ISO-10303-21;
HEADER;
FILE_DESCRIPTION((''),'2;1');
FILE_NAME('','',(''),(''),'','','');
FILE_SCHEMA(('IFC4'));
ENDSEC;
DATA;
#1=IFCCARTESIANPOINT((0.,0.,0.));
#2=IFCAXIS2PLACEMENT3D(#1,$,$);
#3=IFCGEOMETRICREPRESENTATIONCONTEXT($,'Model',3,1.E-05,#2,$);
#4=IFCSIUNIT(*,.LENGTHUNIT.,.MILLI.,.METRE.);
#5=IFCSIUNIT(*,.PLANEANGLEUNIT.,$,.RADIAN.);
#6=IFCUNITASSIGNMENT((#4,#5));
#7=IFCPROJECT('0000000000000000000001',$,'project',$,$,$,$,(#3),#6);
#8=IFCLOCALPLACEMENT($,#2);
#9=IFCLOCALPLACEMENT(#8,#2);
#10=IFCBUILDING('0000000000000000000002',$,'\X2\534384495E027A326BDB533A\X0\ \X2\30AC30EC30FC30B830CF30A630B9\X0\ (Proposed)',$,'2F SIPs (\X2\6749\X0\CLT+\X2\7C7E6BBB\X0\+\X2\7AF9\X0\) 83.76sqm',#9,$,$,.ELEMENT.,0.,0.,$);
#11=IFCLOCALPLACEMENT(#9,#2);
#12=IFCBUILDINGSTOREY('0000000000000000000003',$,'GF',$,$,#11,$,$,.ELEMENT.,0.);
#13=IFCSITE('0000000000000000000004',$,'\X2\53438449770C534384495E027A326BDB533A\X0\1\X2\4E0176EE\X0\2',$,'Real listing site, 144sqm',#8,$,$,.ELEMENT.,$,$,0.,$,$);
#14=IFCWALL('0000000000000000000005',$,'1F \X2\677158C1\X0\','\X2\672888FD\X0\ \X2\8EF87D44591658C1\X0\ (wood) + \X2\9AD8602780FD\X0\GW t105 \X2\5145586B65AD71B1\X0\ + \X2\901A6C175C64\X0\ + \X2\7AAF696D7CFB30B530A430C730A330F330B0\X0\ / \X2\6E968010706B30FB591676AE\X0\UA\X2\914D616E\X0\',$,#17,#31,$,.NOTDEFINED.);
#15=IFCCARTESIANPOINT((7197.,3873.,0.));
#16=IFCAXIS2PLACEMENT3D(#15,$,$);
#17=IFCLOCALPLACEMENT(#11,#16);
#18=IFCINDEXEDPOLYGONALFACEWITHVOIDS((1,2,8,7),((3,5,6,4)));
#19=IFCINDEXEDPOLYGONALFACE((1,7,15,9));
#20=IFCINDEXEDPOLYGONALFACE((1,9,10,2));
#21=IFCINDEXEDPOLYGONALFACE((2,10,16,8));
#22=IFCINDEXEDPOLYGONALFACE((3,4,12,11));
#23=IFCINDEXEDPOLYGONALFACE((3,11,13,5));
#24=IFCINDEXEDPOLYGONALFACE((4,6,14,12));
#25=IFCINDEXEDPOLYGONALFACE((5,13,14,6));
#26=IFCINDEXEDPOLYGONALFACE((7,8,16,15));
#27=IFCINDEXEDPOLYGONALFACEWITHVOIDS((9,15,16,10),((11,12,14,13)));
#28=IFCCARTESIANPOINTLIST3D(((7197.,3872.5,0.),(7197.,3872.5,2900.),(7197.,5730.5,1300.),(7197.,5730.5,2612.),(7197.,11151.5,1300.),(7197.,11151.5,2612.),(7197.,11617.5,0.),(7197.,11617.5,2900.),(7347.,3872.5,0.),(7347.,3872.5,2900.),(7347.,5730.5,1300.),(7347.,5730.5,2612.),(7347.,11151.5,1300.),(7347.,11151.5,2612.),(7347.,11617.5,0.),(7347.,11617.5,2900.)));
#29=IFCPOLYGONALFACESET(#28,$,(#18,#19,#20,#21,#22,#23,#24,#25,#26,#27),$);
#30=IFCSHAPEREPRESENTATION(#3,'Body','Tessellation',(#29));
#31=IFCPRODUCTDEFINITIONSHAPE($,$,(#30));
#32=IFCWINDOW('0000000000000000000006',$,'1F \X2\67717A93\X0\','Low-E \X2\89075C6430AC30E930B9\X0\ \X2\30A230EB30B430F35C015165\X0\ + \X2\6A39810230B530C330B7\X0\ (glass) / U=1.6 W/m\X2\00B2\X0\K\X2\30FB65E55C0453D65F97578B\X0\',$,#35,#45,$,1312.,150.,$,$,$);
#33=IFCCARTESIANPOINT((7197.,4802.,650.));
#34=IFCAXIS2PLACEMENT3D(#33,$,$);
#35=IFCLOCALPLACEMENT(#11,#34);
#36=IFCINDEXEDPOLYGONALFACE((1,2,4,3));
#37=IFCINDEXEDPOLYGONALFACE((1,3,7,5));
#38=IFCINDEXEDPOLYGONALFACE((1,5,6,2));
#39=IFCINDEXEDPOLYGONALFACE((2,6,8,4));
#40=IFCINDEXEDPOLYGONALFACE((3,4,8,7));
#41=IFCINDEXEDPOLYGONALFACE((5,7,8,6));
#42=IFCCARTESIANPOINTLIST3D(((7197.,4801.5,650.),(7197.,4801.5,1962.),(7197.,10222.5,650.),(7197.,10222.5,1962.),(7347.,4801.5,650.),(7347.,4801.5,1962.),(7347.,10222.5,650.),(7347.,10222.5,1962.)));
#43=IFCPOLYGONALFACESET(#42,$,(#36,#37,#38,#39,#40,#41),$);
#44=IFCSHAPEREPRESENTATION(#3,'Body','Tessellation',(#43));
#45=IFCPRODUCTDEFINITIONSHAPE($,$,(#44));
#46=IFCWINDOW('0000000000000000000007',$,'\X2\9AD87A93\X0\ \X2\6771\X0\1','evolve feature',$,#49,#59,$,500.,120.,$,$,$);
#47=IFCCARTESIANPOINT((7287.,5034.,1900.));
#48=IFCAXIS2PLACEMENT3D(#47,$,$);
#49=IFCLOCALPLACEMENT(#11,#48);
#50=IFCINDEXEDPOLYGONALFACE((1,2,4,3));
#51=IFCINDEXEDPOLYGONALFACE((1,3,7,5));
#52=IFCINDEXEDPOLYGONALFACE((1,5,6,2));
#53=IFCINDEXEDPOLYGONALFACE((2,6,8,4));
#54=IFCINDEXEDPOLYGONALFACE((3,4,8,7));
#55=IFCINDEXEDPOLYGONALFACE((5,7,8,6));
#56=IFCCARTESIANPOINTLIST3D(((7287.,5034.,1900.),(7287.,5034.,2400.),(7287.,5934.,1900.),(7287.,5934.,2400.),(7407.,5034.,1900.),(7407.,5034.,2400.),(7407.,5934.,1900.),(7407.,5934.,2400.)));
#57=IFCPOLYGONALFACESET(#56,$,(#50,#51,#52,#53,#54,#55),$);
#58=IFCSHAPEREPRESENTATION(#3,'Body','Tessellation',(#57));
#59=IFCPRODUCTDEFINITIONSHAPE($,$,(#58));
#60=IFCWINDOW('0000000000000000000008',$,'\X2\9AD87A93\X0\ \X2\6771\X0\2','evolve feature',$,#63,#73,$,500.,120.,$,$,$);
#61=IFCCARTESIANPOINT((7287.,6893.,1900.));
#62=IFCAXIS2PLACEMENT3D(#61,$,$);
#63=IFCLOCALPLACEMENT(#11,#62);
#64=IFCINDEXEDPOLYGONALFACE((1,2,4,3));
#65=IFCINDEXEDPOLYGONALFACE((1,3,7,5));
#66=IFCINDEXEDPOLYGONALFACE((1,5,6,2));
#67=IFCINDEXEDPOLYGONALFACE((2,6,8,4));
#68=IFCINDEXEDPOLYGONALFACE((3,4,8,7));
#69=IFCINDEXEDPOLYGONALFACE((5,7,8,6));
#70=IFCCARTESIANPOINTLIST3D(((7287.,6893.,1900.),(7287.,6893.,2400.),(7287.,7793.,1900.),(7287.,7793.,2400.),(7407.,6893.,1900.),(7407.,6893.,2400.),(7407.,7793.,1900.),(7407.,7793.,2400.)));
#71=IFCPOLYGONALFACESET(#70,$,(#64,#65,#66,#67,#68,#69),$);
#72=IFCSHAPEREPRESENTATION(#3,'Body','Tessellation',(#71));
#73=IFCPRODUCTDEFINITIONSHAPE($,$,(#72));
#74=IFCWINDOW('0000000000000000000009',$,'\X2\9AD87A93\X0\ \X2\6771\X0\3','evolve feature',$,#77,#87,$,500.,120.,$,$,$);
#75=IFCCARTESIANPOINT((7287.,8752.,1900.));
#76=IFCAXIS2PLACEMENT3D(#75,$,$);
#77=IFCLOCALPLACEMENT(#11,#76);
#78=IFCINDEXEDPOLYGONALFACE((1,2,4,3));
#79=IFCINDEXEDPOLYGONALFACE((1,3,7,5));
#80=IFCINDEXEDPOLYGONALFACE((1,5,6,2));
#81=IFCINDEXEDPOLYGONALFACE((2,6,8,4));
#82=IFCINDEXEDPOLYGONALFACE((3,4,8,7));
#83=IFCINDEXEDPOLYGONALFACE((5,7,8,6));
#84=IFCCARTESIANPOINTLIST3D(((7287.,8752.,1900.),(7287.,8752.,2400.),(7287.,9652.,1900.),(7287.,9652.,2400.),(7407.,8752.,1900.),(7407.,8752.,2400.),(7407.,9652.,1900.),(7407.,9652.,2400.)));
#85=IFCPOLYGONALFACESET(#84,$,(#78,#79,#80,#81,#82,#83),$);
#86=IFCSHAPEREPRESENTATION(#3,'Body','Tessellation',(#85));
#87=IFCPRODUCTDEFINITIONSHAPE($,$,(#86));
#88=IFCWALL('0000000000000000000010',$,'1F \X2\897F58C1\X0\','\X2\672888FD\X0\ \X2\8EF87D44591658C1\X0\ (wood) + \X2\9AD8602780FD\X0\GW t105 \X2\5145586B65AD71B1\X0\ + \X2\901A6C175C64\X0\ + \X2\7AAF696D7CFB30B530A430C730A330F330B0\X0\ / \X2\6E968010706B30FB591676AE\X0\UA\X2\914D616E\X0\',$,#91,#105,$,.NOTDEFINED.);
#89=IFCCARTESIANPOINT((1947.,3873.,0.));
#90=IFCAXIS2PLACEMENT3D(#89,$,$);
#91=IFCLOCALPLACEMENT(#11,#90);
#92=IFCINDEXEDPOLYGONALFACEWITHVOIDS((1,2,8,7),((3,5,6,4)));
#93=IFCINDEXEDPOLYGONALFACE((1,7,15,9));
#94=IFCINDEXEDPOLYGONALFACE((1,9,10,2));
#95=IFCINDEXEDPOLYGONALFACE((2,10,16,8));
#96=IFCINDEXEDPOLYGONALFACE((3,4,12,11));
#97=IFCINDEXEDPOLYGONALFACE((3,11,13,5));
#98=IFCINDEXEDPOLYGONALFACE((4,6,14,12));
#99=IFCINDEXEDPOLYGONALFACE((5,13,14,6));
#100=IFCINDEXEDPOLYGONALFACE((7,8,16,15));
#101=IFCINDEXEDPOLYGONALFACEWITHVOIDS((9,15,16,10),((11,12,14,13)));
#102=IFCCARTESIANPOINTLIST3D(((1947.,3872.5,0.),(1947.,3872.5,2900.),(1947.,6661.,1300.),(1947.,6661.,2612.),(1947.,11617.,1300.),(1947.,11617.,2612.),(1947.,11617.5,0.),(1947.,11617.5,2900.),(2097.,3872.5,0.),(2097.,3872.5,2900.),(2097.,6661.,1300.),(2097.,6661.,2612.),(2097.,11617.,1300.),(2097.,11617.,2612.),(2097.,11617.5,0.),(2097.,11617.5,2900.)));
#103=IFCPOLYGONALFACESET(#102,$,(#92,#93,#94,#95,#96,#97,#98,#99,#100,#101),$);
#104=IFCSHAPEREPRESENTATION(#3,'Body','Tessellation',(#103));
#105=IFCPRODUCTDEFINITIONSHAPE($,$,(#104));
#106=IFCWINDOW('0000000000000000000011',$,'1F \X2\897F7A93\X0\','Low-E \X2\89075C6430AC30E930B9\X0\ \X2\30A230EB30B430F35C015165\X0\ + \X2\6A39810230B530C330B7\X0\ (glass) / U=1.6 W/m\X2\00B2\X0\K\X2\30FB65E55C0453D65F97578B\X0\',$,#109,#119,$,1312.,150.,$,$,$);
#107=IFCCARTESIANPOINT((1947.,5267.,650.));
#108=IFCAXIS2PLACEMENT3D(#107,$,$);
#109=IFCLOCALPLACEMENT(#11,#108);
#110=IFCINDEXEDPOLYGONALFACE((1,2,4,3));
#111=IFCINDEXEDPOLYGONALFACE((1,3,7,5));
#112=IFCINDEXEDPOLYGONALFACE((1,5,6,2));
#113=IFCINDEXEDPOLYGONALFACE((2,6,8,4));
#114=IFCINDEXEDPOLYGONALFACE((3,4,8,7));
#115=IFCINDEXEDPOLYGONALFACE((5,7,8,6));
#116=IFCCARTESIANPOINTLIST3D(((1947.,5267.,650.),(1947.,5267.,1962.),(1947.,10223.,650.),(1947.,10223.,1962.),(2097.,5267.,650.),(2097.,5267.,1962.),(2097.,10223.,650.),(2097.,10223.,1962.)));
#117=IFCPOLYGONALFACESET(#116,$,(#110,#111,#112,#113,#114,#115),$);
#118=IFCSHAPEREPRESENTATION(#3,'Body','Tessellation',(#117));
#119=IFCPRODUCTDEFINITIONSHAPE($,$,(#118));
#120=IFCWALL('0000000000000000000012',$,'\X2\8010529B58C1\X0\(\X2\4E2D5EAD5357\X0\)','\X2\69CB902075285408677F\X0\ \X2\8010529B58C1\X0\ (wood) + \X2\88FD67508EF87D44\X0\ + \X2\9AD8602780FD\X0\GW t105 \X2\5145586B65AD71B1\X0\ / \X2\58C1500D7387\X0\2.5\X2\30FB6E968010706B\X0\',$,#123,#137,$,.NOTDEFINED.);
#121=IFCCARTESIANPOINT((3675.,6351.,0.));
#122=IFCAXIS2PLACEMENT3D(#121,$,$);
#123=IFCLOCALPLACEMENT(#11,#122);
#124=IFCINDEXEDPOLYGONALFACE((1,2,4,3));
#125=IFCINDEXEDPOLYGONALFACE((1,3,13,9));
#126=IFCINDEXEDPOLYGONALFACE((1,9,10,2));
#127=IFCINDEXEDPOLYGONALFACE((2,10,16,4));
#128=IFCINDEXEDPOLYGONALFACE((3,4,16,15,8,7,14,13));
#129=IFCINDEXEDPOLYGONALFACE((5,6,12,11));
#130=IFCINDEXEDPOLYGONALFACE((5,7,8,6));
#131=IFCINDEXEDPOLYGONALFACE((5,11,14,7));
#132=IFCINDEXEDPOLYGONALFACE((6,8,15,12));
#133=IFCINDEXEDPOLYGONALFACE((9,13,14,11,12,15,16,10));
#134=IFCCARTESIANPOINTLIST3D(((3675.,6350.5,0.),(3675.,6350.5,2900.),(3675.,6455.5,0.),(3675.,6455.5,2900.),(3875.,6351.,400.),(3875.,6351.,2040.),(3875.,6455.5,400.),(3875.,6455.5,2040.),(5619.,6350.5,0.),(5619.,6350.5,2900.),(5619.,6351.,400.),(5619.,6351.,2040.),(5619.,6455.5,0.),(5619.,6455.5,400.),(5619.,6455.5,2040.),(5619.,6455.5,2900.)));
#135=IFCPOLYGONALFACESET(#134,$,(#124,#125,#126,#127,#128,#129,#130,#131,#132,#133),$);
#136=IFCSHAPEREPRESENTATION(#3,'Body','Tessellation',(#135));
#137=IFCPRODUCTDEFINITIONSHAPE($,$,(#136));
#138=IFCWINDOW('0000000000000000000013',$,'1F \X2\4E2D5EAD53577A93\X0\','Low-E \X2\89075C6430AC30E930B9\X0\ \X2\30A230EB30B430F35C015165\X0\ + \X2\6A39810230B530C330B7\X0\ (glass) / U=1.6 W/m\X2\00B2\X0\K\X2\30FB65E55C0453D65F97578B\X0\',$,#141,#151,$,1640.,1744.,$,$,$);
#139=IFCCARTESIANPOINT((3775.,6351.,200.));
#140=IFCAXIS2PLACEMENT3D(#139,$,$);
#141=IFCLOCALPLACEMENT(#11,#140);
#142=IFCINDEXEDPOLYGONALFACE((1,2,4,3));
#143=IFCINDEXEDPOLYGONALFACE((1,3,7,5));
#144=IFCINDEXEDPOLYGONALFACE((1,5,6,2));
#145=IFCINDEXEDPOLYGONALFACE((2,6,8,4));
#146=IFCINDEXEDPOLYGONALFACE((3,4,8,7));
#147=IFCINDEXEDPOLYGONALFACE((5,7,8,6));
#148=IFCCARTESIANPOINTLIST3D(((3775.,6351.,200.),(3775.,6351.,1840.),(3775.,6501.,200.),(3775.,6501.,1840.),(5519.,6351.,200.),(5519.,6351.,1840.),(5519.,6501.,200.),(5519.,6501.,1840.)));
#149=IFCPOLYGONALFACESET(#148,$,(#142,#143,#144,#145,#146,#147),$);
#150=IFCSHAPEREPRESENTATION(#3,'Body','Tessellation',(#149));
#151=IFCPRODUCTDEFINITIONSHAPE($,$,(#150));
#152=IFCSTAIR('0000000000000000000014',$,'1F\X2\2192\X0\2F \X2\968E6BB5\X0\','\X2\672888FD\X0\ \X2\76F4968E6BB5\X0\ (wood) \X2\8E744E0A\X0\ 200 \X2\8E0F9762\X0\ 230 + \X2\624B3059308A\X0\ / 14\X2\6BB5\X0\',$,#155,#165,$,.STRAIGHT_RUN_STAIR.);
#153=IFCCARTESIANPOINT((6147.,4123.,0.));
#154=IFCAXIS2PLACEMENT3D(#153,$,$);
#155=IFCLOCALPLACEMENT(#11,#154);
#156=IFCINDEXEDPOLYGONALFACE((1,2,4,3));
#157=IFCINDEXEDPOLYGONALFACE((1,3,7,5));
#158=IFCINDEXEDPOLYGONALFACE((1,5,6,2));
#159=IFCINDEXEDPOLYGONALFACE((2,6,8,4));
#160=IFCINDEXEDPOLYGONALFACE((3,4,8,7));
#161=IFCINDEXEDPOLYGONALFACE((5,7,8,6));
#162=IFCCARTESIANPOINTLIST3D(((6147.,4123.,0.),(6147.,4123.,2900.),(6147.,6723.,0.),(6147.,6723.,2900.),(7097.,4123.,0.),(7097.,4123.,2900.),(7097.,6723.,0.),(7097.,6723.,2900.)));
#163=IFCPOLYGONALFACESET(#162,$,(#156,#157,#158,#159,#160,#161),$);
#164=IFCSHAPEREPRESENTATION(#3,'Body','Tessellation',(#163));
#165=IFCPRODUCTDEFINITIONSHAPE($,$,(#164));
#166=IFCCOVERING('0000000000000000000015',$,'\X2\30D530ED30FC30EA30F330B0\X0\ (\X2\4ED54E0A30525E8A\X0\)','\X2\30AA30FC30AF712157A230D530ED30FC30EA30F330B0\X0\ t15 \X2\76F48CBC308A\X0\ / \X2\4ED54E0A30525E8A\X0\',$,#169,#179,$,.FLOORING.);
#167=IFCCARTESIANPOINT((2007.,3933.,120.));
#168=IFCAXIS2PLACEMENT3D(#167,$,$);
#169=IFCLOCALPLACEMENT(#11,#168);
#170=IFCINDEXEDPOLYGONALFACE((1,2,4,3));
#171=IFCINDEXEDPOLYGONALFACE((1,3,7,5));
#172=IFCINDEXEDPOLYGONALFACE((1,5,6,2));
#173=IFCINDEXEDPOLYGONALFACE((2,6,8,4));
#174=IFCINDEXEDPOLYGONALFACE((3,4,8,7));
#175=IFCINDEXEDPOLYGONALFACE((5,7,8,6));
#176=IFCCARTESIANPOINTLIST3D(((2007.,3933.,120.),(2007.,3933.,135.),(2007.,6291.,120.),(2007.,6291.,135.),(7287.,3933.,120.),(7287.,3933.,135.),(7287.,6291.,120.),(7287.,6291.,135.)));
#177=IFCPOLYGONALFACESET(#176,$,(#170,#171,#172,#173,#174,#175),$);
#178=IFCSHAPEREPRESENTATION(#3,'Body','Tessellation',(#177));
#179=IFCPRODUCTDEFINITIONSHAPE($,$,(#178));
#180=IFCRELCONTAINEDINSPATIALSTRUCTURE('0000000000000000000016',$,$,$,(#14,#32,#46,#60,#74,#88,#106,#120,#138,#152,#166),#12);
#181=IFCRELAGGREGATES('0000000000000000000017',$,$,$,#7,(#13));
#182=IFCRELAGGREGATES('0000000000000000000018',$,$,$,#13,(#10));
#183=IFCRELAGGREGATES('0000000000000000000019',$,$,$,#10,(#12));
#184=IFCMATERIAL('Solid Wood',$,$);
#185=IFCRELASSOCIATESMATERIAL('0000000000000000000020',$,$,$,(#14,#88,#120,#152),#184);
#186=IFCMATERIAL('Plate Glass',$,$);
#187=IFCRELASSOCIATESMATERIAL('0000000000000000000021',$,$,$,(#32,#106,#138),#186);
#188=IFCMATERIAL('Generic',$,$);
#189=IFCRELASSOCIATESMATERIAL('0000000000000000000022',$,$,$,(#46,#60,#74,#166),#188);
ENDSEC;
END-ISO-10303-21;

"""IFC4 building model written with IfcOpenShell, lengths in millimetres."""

from ifc_helpers import new_model, si_unit, frame, frame_2d, origin, place, context, project, spatial, rectangle, extrude, material, element, fill, save


model = new_model("IFC4")

# Units and contexts
model_context = context("Model", 3, precision=1e-05, world=origin())
ifc_project = project(units=[si_unit("LENGTHUNIT", "METRE", prefix="MILLI"), si_unit("PLANEANGLEUNIT", "RADIAN")], contexts=[model_context])

# Site, building, storey
site_placement = place(None, origin())
site = spatial("IfcSite", under=ifc_project, at=site_placement, Name="千葉県千葉市稲毛区1丁目2", ObjectType="Real listing site, 144sqm", CompositionType="ELEMENT", RefElevation=0.0)
building_placement = place(site_placement, origin())
building = spatial("IfcBuilding", under=site, at=building_placement, Name="千葉市稲毛区 ガレージハウス (Proposed)", ObjectType="2F SIPs (杉CLT+籾殻+竹) 83.76sqm", CompositionType="ELEMENT", ElevationOfRefHeight=0.0, ElevationOfTerrain=0.0)
storey_placement = place(building_placement, origin())
storey = spatial("IfcBuildingStorey", under=building, at=storey_placement, Name="GF", CompositionType="ELEMENT", Elevation=0.0)

# Shared definitions
ifc_material_1 = material(Name="Solid Wood")
ifc_material_2 = material(Name="Generic")

# Shared definitions
ifc_material_3 = material(Name="Plate Glass")

# Wall, openings, windows
wall_1_placement = place(storey_placement, frame((7197.0, 3873.0, 0.0)))
wall_1 = element("IfcWall", 1, at=wall_1_placement, inside=storey, material=ifc_material_1, Name="1F 東壁", Description="木製 軸組外壁 (wood) + 高性能GW t105 充填断熱 + 通気層 + 窯業系サイディング / 準耐火・外皮UA配慮", PredefinedType="NOTDEFINED", context=model_context, shape_type="SweptSolid", body=[
    extrude(rectangle(XDim=150.0, YDim=7745.0, at=frame_2d((75.0, 3872.0))), frame((7197.0, 3873.0, 0.0)), (0.0, 0.0, 1.0), 2900.0),
])
opening_1_placement = place(storey_placement, frame((7197.0, 4802.0, 650.0)))
opening_1 = element("IfcOpeningElement", 2, at=opening_1_placement, cuts=wall_1, PredefinedType="NOTDEFINED", context=model_context, shape_type="SweptSolid", body=[
    extrude(rectangle(XDim=150.0, YDim=5421.0, at=frame_2d((75.0, 2710.0))), frame((7197.0, 4802.0, 650.0)), (0.0, 0.0, 1.0), 1312.0),
])
opening_2_placement = place(storey_placement, frame((7287.0, 5034.0, 1900.0)))
opening_2 = element("IfcOpeningElement", 3, at=opening_2_placement, cuts=wall_1, PredefinedType="NOTDEFINED", context=model_context, shape_type="SweptSolid", body=[
    extrude(rectangle(XDim=120.0, YDim=900.0, at=frame_2d((60.0, 450.0))), frame((7287.0, 5034.0, 1900.0)), (0.0, 0.0, 1.0), 500.0),
])
opening_3_placement = place(storey_placement, frame((7287.0, 6893.0, 1900.0)))
opening_3 = element("IfcOpeningElement", 4, at=opening_3_placement, cuts=wall_1, PredefinedType="NOTDEFINED", context=model_context, shape_type="SweptSolid", body=[
    extrude(rectangle(XDim=120.0, YDim=900.0, at=frame_2d((60.0, 450.0))), frame((7287.0, 6893.0, 1900.0)), (0.0, 0.0, 1.0), 500.0),
])
opening_4_placement = place(storey_placement, frame((7287.0, 8752.0, 1900.0)))
opening_4 = element("IfcOpeningElement", 5, at=opening_4_placement, cuts=wall_1, PredefinedType="NOTDEFINED", context=model_context, shape_type="SweptSolid", body=[
    extrude(rectangle(XDim=120.0, YDim=900.0, at=frame_2d((60.0, 450.0))), frame((7287.0, 8752.0, 1900.0)), (0.0, 0.0, 1.0), 500.0),
])
window_1_placement = place(storey_placement, frame((7197.0, 4802.0, 650.0)))
window_1 = element("IfcWindow", 6, at=window_1_placement, inside=storey, material=ifc_material_3, Name="1F 東窓", Description="Low-E 複層ガラス アルゴン封入 + 樹脂サッシ (glass) / U=1.6 W/m²K・日射取得型", OverallHeight=1312.0, OverallWidth=150.0, context=model_context, shape_type="SweptSolid", body=[
    extrude(rectangle(XDim=150.0, YDim=5421.0, at=frame_2d((75.0, 2710.0))), frame((7197.0, 4802.0, 650.0)), (0.0, 0.0, 1.0), 1312.0),
])
fill(opening_1, window_1)
window_2_placement = place(storey_placement, frame((7287.0, 5034.0, 1900.0)))
window_2 = element("IfcWindow", 7, at=window_2_placement, inside=storey, material=ifc_material_2, Name="高窓 東1", Description="evolve feature", OverallHeight=500.0, OverallWidth=120.0, context=model_context, shape_type="SweptSolid", body=[
    extrude(rectangle(XDim=120.0, YDim=900.0, at=frame_2d((60.0, 450.0))), frame((7287.0, 5034.0, 1900.0)), (0.0, 0.0, 1.0), 500.0),
])
fill(opening_2, window_2)
window_3_placement = place(storey_placement, frame((7287.0, 6893.0, 1900.0)))
window_3 = element("IfcWindow", 8, at=window_3_placement, inside=storey, material=ifc_material_2, Name="高窓 東2", Description="evolve feature", OverallHeight=500.0, OverallWidth=120.0, context=model_context, shape_type="SweptSolid", body=[
    extrude(rectangle(XDim=120.0, YDim=900.0, at=frame_2d((60.0, 450.0))), frame((7287.0, 6893.0, 1900.0)), (0.0, 0.0, 1.0), 500.0),
])
fill(opening_3, window_3)
window_4_placement = place(storey_placement, frame((7287.0, 8752.0, 1900.0)))
window_4 = element("IfcWindow", 9, at=window_4_placement, inside=storey, material=ifc_material_2, Name="高窓 東3", Description="evolve feature", OverallHeight=500.0, OverallWidth=120.0, context=model_context, shape_type="SweptSolid", body=[
    extrude(rectangle(XDim=120.0, YDim=900.0, at=frame_2d((60.0, 450.0))), frame((7287.0, 8752.0, 1900.0)), (0.0, 0.0, 1.0), 500.0),
])
fill(opening_4, window_4)

# Walls, openings, windows
wall_2_placement = place(storey_placement, frame((1947.0, 3873.0, 0.0)))
wall_2 = element("IfcWall", 10, at=wall_2_placement, inside=storey, material=ifc_material_1, Name="1F 西壁", Description="木製 軸組外壁 (wood) + 高性能GW t105 充填断熱 + 通気層 + 窯業系サイディング / 準耐火・外皮UA配慮", PredefinedType="NOTDEFINED", context=model_context, shape_type="SweptSolid", body=[
    extrude(rectangle(XDim=150.0, YDim=7745.0, at=frame_2d((75.0, 3872.0))), frame((1947.0, 3873.0, 0.0)), (0.0, 0.0, 1.0), 2900.0),
])
opening_5_placement = place(storey_placement, frame((1947.0, 5267.0, 650.0)))
opening_5 = element("IfcOpeningElement", 11, at=opening_5_placement, cuts=wall_2, PredefinedType="NOTDEFINED", context=model_context, shape_type="SweptSolid", body=[
    extrude(rectangle(XDim=150.0, YDim=4956.0, at=frame_2d((75.0, 2478.0))), frame((1947.0, 5267.0, 650.0)), (0.0, 0.0, 1.0), 1312.0),
])
window_5_placement = place(storey_placement, frame((1947.0, 5267.0, 650.0)))
window_5 = element("IfcWindow", 12, at=window_5_placement, inside=storey, material=ifc_material_3, Name="1F 西窓", Description="Low-E 複層ガラス アルゴン封入 + 樹脂サッシ (glass) / U=1.6 W/m²K・日射取得型", OverallHeight=1312.0, OverallWidth=150.0, context=model_context, shape_type="SweptSolid", body=[
    extrude(rectangle(XDim=150.0, YDim=4956.0, at=frame_2d((75.0, 2478.0))), frame((1947.0, 5267.0, 650.0)), (0.0, 0.0, 1.0), 1312.0),
])
fill(opening_5, window_5)
wall_3_placement = place(storey_placement, frame((3675.0, 6351.0, 0.0)))
wall_3 = element("IfcWall", 13, at=wall_3_placement, inside=storey, material=ifc_material_1, Name="耐力壁(中庭南)", Description="構造用合板 耐力壁 (wood) + 製材軸組 + 高性能GW t105 充填断熱 / 壁倍率2.5・準耐火", PredefinedType="NOTDEFINED", context=model_context, shape_type="SweptSolid", body=[
    extrude(rectangle(XDim=1944.0, YDim=105.0, at=frame_2d((972.0, 52.0))), frame((3675.0, 6351.0, 0.0)), (0.0, 0.0, 1.0), 2900.0),
])
opening_6_placement = place(storey_placement, frame((3775.0, 6351.0, 200.0)))
opening_6 = element("IfcOpeningElement", 14, at=opening_6_placement, cuts=wall_3, PredefinedType="NOTDEFINED", context=model_context, shape_type="SweptSolid", body=[
    extrude(rectangle(XDim=1744.0, YDim=150.0, at=frame_2d((872.0, 75.0))), frame((3775.0, 6351.0, 200.0)), (0.0, 0.0, 1.0), 1640.0),
])
window_6_placement = place(storey_placement, frame((3775.0, 6351.0, 200.0)))
window_6 = element("IfcWindow", 15, at=window_6_placement, inside=storey, material=ifc_material_3, Name="1F 中庭南窓", Description="Low-E 複層ガラス アルゴン封入 + 樹脂サッシ (glass) / U=1.6 W/m²K・日射取得型", OverallHeight=1640.0, OverallWidth=1744.0, context=model_context, shape_type="SweptSolid", body=[
    extrude(rectangle(XDim=1744.0, YDim=150.0, at=frame_2d((872.0, 75.0))), frame((3775.0, 6351.0, 200.0)), (0.0, 0.0, 1.0), 1640.0),
])
fill(opening_6, window_6)

# Stair
stair_placement = place(storey_placement, frame((6147.0, 4123.0, 0.0)))
element("IfcStair", 16, at=stair_placement, inside=storey, material=ifc_material_1, Name="1F→2F 階段", Description="木製 直階段 (wood) 蹴上 200 踏面 230 + 手すり / 14段", PredefinedType="STRAIGHT_RUN_STAIR", context=model_context, shape_type="SweptSolid", body=[
    extrude(rectangle(XDim=950.0, YDim=2600.0, at=frame_2d((475.0, 1300.0))), frame((6147.0, 4123.0, 0.0)), (0.0, 0.0, 1.0), 2900.0),
])

# Covering
covering_placement = place(storey_placement, frame((2007.0, 3933.0, 120.0)))
element("IfcCovering", 17, at=covering_placement, inside=storey, material=ifc_material_2, Name="フローリング (仕上げ床)", Description="オーク無垢フローリング t15 直貼り / 仕上げ床", PredefinedType="FLOORING", context=model_context, shape_type="SweptSolid", body=[
    extrude(rectangle(XDim=5280.0, YDim=2358.0, at=frame_2d((2640.0, 1179.0))), frame((2007.0, 3933.0, 120.0)), (0.0, 0.0, 1.0), 15.0),
])

save(model, "model.ifc")
